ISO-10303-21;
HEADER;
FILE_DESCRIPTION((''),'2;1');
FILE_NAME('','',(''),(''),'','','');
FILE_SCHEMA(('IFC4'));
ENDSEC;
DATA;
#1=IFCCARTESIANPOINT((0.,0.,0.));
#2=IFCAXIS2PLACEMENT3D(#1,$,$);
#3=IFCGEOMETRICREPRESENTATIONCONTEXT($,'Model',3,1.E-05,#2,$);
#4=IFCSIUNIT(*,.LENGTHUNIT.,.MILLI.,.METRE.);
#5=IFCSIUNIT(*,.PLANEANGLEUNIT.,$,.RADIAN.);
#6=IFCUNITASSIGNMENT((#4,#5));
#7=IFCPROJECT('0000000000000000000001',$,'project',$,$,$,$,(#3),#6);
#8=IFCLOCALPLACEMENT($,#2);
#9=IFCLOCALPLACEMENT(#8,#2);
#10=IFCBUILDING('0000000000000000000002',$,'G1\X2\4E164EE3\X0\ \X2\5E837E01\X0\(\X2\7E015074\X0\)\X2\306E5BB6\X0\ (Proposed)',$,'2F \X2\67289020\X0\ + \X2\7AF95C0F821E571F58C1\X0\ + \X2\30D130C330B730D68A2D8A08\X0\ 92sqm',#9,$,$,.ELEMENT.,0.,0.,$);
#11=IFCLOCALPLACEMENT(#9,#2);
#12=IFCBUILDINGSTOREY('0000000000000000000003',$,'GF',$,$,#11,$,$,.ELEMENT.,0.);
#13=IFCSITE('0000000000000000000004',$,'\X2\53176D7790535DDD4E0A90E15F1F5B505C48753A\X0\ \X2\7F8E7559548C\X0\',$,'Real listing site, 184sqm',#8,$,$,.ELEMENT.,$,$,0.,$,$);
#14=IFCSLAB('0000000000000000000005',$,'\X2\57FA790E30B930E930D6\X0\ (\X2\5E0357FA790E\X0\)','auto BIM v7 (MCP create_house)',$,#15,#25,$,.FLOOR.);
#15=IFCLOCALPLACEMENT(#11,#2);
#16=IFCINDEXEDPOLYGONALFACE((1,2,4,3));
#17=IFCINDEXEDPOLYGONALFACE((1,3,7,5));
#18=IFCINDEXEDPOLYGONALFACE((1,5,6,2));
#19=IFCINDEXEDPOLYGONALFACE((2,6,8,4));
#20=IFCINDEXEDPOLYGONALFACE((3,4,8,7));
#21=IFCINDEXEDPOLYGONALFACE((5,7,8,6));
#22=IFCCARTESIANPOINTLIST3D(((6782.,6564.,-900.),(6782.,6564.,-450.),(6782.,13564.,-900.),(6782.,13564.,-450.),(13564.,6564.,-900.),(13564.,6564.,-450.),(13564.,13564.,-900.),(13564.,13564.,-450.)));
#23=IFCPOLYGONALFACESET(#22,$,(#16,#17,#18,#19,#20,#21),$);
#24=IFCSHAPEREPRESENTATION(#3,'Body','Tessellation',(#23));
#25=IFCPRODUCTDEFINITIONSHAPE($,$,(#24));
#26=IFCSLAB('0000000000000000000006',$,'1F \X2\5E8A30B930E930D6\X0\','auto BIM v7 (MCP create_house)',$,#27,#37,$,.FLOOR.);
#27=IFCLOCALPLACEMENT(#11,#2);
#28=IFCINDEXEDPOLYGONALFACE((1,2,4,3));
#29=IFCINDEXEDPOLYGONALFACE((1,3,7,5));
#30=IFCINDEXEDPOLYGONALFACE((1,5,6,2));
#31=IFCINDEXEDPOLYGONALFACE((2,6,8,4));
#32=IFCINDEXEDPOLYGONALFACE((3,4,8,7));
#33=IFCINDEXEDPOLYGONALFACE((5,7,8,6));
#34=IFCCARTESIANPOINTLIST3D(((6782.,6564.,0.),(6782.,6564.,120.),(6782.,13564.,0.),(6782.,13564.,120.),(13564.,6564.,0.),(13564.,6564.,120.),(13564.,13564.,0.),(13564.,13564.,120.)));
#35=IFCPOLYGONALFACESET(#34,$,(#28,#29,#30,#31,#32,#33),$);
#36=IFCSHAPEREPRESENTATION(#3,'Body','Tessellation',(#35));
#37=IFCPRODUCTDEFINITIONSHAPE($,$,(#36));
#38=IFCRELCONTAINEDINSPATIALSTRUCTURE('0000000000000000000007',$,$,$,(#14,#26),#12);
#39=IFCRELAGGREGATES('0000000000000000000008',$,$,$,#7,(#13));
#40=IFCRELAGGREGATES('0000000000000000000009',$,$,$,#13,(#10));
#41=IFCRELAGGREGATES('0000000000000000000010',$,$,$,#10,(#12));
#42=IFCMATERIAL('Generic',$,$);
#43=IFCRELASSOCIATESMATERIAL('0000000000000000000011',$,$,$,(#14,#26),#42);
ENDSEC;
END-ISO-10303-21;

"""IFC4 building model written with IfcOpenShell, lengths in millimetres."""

from ifc_helpers import new_model, si_unit, frame, frame_2d, origin, place, context, project, spatial, rectangle, extrude, material, element, save


model = new_model("IFC4")

# Units and contexts
model_context = context("Model", 3, precision=1e-05, world=origin())
ifc_project = project(units=[si_unit("LENGTHUNIT", "METRE", prefix="MILLI"), si_unit("PLANEANGLEUNIT", "RADIAN")], contexts=[model_context])

# Site, building, storey
site_placement = place(None, origin())
site = spatial("IfcSite", under=ifc_project, at=site_placement, Name="北海道川上郡弟子屈町 美留和", ObjectType="Real listing site, 184sqm", CompositionType="ELEMENT", RefElevation=0.0)
building_placement = place(site_placement, origin())
building = spatial("IfcBuilding", under=site, at=building_placement, Name="G1世代 広縁(縁側)の家 (Proposed)", ObjectType="2F 木造 + 竹小舞土壁 + パッシブ設計 92sqm", CompositionType="ELEMENT", ElevationOfRefHeight=0.0, ElevationOfTerrain=0.0)
storey_placement = place(building_placement, origin())
storey = spatial("IfcBuildingStorey", under=building, at=storey_placement, Name="GF", CompositionType="ELEMENT", Elevation=0.0)

# Slabs
ifc_material = material(Name="Generic")
slab_1_placement = place(storey_placement, frame((3391.0, 3282.0, -450.0)))
element("IfcSlab", 1, at=slab_1_placement, inside=storey, material=ifc_material, Name="基礎スラブ (布基礎)", Description="auto BIM v7 (MCP create_house)", PredefinedType="FLOOR", context=model_context, shape_type="SweptSolid", body=[
    extrude(rectangle(XDim=6782.0, YDim=7000.0, at=frame_2d((3391.0, 3500.0))), frame((3391.0, 3282.0, -450.0)), (0.0, 0.0, 1.0), 450.0),
])
slab_2_placement = place(storey_placement, frame((3391.0, 3282.0, 0.0)))
element("IfcSlab", 2, at=slab_2_placement, inside=storey, material=ifc_material, Name="1F 床スラブ", Description="auto BIM v7 (MCP create_house)", PredefinedType="FLOOR", context=model_context, shape_type="SweptSolid", body=[
    extrude(rectangle(XDim=6782.0, YDim=7000.0, at=frame_2d((3391.0, 3500.0))), frame((3391.0, 3282.0, 0.0)), (0.0, 0.0, 1.0), 120.0),
])

save(model, "model.ifc")
